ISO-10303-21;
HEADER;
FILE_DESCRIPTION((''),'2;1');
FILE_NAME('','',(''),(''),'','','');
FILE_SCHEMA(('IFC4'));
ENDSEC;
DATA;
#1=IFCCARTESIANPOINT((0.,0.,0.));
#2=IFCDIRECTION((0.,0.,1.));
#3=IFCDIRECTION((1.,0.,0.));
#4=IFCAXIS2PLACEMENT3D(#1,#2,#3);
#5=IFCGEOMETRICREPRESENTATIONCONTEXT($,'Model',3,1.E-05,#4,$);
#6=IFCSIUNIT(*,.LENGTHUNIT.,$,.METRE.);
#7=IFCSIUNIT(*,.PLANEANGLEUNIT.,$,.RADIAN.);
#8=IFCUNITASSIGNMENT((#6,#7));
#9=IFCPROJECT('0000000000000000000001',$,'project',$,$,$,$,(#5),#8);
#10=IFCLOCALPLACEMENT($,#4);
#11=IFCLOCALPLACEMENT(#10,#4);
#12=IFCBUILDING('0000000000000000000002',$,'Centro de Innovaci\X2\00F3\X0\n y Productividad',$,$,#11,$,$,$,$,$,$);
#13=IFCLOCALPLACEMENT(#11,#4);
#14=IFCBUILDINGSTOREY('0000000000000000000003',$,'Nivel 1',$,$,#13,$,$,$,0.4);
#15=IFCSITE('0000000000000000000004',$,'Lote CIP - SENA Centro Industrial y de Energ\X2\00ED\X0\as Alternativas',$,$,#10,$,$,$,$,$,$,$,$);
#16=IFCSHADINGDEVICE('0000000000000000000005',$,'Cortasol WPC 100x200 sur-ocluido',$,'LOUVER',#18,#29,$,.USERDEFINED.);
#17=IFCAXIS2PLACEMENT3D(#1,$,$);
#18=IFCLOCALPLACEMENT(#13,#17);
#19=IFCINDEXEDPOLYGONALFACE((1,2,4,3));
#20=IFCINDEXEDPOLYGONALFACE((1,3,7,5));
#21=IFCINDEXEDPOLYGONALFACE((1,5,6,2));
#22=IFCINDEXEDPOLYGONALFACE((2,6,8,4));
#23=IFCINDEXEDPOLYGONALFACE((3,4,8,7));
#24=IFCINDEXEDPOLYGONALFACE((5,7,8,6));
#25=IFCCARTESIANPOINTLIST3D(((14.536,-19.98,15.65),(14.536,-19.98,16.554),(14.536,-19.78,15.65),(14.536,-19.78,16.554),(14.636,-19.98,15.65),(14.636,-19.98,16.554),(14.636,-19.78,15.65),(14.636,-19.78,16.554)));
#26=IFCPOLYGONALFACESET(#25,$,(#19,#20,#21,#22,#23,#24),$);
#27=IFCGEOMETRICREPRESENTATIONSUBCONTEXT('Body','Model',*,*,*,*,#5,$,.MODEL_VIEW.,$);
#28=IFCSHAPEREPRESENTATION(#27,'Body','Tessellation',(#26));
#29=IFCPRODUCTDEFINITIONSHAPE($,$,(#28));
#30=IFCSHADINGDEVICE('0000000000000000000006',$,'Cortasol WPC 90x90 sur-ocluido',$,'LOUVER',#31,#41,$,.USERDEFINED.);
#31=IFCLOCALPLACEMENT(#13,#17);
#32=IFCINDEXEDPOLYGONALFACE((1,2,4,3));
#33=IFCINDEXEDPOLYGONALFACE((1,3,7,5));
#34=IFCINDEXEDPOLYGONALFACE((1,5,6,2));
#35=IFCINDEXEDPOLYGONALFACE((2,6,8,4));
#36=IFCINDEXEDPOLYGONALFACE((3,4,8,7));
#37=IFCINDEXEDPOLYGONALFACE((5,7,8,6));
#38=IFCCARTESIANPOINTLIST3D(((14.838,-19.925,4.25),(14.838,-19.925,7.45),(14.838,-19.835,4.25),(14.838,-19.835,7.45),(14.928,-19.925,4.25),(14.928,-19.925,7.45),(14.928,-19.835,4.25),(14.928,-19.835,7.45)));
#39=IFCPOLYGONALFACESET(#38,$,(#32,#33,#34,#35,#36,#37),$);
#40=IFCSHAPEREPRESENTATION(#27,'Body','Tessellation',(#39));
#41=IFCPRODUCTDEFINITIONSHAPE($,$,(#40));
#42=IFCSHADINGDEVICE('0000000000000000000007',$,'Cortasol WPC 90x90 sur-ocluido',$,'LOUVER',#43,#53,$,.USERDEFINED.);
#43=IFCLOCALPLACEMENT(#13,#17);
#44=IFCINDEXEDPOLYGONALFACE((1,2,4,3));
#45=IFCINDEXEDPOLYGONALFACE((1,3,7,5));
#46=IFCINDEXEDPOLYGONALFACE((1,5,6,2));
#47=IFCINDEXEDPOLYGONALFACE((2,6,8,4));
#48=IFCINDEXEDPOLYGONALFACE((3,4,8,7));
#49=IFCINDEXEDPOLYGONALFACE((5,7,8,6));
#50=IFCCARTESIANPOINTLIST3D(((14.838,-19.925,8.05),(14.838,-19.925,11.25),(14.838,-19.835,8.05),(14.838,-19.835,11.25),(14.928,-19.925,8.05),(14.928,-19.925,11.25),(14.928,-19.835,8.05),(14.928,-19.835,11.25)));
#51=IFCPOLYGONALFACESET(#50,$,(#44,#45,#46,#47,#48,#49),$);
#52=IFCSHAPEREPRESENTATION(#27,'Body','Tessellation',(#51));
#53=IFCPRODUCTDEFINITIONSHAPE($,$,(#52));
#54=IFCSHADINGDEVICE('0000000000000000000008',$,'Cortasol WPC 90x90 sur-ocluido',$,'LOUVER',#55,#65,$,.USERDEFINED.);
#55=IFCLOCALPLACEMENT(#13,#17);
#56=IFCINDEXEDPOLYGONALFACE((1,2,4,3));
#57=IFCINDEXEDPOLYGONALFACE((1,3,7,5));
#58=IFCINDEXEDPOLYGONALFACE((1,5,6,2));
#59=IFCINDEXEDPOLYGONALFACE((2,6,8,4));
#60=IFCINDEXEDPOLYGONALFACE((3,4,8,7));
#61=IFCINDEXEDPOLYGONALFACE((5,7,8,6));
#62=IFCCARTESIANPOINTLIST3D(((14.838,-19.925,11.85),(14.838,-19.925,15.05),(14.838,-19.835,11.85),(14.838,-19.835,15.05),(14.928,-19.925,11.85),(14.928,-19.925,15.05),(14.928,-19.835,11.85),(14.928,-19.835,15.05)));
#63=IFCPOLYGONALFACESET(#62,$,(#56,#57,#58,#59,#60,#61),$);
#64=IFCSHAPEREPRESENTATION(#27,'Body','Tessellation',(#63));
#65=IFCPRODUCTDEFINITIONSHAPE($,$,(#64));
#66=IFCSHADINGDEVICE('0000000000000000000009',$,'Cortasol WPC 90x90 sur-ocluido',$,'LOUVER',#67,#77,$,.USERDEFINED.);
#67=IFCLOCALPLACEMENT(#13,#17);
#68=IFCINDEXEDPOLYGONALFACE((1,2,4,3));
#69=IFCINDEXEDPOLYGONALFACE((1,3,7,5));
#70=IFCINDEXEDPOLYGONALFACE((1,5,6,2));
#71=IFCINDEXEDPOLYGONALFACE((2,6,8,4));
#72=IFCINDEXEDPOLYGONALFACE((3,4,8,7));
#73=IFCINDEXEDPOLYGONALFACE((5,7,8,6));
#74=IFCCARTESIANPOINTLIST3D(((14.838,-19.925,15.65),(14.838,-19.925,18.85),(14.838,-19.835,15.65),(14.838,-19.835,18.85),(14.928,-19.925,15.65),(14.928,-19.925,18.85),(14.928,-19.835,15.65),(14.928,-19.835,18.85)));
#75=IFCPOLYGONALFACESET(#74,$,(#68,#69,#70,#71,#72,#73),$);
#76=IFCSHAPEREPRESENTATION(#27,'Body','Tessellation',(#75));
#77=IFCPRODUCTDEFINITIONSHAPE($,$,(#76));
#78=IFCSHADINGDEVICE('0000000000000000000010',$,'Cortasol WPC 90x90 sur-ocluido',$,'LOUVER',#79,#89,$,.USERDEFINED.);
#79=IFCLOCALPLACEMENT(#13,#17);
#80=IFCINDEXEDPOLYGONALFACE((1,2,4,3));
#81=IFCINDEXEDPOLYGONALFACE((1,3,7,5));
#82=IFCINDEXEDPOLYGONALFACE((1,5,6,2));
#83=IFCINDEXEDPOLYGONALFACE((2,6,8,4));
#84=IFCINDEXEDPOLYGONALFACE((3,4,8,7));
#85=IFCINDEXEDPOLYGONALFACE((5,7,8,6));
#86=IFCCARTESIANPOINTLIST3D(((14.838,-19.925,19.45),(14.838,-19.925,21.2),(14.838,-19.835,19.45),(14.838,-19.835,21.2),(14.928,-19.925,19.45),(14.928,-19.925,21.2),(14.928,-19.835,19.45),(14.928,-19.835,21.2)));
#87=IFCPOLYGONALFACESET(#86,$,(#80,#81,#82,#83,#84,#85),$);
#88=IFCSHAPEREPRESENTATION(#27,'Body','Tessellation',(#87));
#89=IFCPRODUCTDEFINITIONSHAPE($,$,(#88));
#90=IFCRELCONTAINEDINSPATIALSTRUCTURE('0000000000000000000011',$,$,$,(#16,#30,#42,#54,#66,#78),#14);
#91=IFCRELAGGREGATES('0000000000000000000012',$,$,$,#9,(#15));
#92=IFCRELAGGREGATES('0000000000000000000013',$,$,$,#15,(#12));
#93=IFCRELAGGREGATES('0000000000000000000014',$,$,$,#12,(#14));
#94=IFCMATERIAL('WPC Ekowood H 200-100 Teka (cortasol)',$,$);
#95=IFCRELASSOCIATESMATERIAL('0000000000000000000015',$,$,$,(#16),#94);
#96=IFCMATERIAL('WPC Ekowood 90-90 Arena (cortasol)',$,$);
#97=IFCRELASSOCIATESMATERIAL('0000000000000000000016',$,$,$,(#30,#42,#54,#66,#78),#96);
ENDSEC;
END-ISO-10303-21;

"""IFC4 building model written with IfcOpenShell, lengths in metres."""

from ifc_helpers import new_model, si_unit, frame, origin_with_axes, place, context, subcontext, project, spatial, polyline, outline, extrude, material, element, save


model = new_model("IFC4")

# Units and contexts
model_context = context("Model", 3, precision=1e-05, world=origin_with_axes())
body_context = subcontext(model_context, "Body", "Model", "MODEL_VIEW")
ifc_project = project(units=[si_unit("LENGTHUNIT", "METRE"), si_unit("PLANEANGLEUNIT", "RADIAN")], contexts=[model_context])

# Site, building, storey
site_placement = place(None, origin_with_axes())
site = spatial("IfcSite", under=ifc_project, at=site_placement, Name="Lote CIP - SENA Centro Industrial y de Energías Alternativas")
building_placement = place(site_placement, origin_with_axes())
building = spatial("IfcBuilding", under=site, at=building_placement, Name="Centro de Innovación y Productividad")
storey_placement = place(building_placement, origin_with_axes())
storey = spatial("IfcBuildingStorey", under=building, at=storey_placement, Name="Nivel 1", Elevation=0.4)

# Shading devices
ifc_material_1 = material(Name="WPC Ekowood 90-90 Arena (cortasol)")
ifc_material_2 = material(Name="WPC Ekowood H 200-100 Teka (cortasol)")
shading_device_1_placement = place(storey_placement, origin_with_axes())
element("IfcShadingDevice", 1, at=shading_device_1_placement, inside=storey, material=ifc_material_2, Name="Cortasol WPC 100x200 sur-ocluido", ObjectType="LOUVER", PredefinedType="USERDEFINED", context=body_context, shape_type="SweptSolid", body=[
    extrude(outline(polyline([(14.536, -19.98), (14.536, -19.78), (14.636, -19.78), (14.636, -19.98), (14.536, -19.98)])), frame((0.0, 0.0, 15.65)), (0.0, 0.0, 1.0), 0.904),
])
shading_device_2_placement = place(storey_placement, origin_with_axes())
element("IfcShadingDevice", 2, at=shading_device_2_placement, inside=storey, material=ifc_material_1, Name="Cortasol WPC 90x90 sur-ocluido", ObjectType="LOUVER", PredefinedType="USERDEFINED", context=body_context, shape_type="SweptSolid", body=[
    extrude(outline(polyline([(14.838, -19.925), (14.838, -19.835), (14.928, -19.835), (14.928, -19.925), (14.838, -19.925)])), frame((0.0, 0.0, 4.25)), (0.0, 0.0, 1.0), 3.2),
])
shading_device_3_placement = place(storey_placement, origin_with_axes())
element("IfcShadingDevice", 3, at=shading_device_3_placement, inside=storey, material=ifc_material_1, Name="Cortasol WPC 90x90 sur-ocluido", ObjectType="LOUVER", PredefinedType="USERDEFINED", context=body_context, shape_type="SweptSolid", body=[
    extrude(outline(polyline([(14.838, -19.925), (14.838, -19.835), (14.928, -19.835), (14.928, -19.925), (14.838, -19.925)])), frame((0.0, 0.0, 8.05)), (0.0, 0.0, 1.0), 3.2),
])
shading_device_4_placement = place(storey_placement, origin_with_axes())
element("IfcShadingDevice", 4, at=shading_device_4_placement, inside=storey, material=ifc_material_1, Name="Cortasol WPC 90x90 sur-ocluido", ObjectType="LOUVER", PredefinedType="USERDEFINED", context=body_context, shape_type="SweptSolid", body=[
    extrude(outline(polyline([(14.838, -19.925), (14.838, -19.835), (14.928, -19.835), (14.928, -19.925), (14.838, -19.925)])), frame((0.0, 0.0, 11.85)), (0.0, 0.0, 1.0), 3.2),
])
shading_device_5_placement = place(storey_placement, origin_with_axes())
element("IfcShadingDevice", 5, at=shading_device_5_placement, inside=storey, material=ifc_material_1, Name="Cortasol WPC 90x90 sur-ocluido", ObjectType="LOUVER", PredefinedType="USERDEFINED", context=body_context, shape_type="SweptSolid", body=[
    extrude(outline(polyline([(14.838, -19.925), (14.838, -19.835), (14.928, -19.835), (14.928, -19.925), (14.838, -19.925)])), frame((0.0, 0.0, 15.65)), (0.0, 0.0, 1.0), 3.2),
])
shading_device_6_placement = place(storey_placement, origin_with_axes())
element("IfcShadingDevice", 6, at=shading_device_6_placement, inside=storey, material=ifc_material_1, Name="Cortasol WPC 90x90 sur-ocluido", ObjectType="LOUVER", PredefinedType="USERDEFINED", context=body_context, shape_type="SweptSolid", body=[
    extrude(outline(polyline([(14.838, -19.925), (14.838, -19.835), (14.928, -19.835), (14.928, -19.925), (14.838, -19.925)])), frame((0.0, 0.0, 19.45)), (0.0, 0.0, 1.0), 1.75),
])

save(model, "model.ifc")
